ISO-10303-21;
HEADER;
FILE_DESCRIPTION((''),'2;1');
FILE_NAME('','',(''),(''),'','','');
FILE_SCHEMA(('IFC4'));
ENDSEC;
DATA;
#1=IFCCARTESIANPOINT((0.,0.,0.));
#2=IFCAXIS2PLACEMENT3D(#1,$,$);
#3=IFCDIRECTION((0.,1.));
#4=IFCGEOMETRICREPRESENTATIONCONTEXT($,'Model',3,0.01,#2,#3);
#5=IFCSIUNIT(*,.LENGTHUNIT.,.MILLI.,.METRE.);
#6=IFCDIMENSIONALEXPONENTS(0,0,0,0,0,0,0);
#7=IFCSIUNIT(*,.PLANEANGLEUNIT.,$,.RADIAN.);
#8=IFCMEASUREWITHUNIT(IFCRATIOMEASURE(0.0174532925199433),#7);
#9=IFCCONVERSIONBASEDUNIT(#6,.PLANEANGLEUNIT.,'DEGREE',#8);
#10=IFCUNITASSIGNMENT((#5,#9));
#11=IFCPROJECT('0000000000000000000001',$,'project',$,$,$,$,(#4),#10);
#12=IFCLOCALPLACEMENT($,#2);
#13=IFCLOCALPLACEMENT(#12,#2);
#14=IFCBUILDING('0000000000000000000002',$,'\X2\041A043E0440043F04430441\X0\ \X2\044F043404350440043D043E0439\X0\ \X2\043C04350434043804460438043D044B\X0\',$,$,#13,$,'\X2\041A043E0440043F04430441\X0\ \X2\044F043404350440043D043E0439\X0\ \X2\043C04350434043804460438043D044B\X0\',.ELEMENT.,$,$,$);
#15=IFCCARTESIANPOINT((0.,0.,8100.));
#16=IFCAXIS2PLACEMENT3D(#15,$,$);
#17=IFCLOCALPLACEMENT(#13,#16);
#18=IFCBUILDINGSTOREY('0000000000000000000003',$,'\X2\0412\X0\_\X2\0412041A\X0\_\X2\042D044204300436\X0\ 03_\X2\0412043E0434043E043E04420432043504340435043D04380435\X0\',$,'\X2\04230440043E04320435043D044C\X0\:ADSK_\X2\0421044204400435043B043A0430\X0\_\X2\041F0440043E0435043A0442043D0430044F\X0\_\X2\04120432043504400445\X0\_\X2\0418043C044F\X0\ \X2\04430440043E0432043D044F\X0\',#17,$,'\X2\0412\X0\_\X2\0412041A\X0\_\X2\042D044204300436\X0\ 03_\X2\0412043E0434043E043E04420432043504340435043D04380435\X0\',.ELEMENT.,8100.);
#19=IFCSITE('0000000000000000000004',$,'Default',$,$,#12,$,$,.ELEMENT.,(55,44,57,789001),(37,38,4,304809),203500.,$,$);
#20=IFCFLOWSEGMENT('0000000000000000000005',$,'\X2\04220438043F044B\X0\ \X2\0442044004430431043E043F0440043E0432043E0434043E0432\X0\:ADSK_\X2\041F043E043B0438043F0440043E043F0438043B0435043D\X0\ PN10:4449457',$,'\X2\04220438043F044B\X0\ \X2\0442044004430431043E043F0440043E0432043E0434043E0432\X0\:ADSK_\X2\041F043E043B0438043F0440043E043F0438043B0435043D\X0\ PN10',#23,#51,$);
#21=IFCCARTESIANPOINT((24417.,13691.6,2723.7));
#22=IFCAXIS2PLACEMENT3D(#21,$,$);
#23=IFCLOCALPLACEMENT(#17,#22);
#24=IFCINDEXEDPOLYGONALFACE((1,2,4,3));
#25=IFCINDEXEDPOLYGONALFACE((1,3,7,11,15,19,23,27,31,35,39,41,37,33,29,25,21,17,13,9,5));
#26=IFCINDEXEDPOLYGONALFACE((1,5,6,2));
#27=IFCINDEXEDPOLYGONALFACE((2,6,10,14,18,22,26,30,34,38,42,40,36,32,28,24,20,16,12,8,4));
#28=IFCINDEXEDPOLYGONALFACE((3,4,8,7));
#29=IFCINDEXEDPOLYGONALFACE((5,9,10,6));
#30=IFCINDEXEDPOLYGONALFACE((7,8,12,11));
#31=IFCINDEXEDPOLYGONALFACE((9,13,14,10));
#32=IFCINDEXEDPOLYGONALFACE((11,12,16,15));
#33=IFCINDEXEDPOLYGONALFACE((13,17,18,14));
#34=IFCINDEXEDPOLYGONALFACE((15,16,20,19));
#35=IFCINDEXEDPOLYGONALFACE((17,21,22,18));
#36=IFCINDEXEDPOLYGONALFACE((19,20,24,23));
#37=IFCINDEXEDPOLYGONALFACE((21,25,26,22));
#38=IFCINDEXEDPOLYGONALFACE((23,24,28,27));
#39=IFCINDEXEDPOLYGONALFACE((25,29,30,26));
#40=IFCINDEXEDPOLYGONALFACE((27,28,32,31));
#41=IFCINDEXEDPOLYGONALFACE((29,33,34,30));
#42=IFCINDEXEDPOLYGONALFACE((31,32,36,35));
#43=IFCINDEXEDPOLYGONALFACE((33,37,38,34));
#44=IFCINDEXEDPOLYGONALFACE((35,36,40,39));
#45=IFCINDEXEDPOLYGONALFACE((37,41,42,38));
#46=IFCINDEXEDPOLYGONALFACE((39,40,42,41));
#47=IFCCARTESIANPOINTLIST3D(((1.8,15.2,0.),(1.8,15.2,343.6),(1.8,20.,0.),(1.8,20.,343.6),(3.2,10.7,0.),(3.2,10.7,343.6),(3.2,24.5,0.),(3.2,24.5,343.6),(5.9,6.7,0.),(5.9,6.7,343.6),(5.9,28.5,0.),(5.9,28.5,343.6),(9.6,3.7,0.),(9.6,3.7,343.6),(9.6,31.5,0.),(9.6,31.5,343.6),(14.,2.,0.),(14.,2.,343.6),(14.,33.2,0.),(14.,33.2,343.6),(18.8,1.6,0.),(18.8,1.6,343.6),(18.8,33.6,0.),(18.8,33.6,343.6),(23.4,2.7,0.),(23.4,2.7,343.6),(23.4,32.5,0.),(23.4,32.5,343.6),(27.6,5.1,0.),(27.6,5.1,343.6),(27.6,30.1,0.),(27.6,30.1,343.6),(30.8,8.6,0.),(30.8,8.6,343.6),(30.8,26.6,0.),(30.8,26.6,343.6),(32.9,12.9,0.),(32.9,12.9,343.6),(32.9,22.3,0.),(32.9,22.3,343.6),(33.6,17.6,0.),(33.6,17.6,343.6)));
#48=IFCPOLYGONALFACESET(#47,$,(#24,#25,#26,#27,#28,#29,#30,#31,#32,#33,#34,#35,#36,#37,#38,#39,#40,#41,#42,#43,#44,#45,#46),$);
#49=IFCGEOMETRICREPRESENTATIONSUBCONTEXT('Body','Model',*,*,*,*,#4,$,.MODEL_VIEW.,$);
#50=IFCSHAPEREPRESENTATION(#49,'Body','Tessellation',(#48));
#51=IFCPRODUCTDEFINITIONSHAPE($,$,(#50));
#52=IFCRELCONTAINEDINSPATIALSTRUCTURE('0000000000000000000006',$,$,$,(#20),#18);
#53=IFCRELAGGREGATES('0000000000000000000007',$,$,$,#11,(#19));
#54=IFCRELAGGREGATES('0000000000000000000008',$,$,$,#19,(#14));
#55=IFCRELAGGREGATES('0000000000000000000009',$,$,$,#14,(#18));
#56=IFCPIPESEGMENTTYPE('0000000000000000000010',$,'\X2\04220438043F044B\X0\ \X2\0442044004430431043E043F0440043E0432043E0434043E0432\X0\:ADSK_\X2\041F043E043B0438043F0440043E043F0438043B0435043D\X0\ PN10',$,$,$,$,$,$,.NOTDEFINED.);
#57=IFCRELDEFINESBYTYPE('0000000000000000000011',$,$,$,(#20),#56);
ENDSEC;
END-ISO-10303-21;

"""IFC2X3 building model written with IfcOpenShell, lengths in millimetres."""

from ifc_helpers import new_model, entity, si_unit, converted_unit, direction, frame, origin, origin_2d_with_axis, place, context, subcontext, project, spatial, circle, extrude, type_object, element, save


model = new_model("IFC2X3")

# Units and contexts
model_context = context("Model", 3, precision=0.01, world=origin(), true_north=direction((0.0, 1.0)))
body_context = subcontext(model_context, "Body", "Model", "MODEL_VIEW")
ifc_project = project(units=[si_unit("LENGTHUNIT", "METRE", prefix="MILLI"), converted_unit("PLANEANGLEUNIT", "DEGREE", entity("IfcRatioMeasure", 0.0174532925199433), si_unit("PLANEANGLEUNIT", "RADIAN"), dimensions=[0, 0, 0, 0, 0, 0, 0])], contexts=[model_context])

# Site, building, storey
site_placement = place(None, origin())
site = spatial("IfcSite", under=ifc_project, at=site_placement, Name="Default", CompositionType="ELEMENT", RefLatitude=(55, 44, 57, 789001), RefLongitude=(37, 38, 4, 304809), RefElevation=203500.0)
building_placement = place(site_placement, origin())
building = spatial("IfcBuilding", under=site, at=building_placement, Name="Корпус ядерной медицины", LongName="Корпус ядерной медицины", CompositionType="ELEMENT")
storey_placement = place(building_placement, frame((0.0, 0.0, 8100.0)))
storey = spatial("IfcBuildingStorey", under=building, at=storey_placement, Name="В_ВК_Этаж 03_Водоотведение", ObjectType="Уровень:ADSK_Стрелка_Проектная_Вверх_Имя уровня", LongName="В_ВК_Этаж 03_Водоотведение", CompositionType="ELEMENT", Elevation=8100.0)

# Flow segment
pipe_segment_type_1 = type_object("IfcPipeSegmentType", Name="Типы трубопроводов:ADSK_Полипропилен PN10", PredefinedType="NOTDEFINED")
flow_segment_1_placement = place(storey_placement, frame((24417.0, 13691.6, 2723.7)))
element("IfcFlowSegment", 1, at=flow_segment_1_placement, inside=storey, type_object=pipe_segment_type_1, Name="Типы трубопроводов:ADSK_Полипропилен PN10:4449457", ObjectType="Типы трубопроводов:ADSK_Полипропилен PN10", context=body_context, shape_type="SweptSolid", body=[
    extrude(circle(Radius=16.0, at=origin_2d_with_axis()), frame((17.6, 17.6, 0.0)), (0.0, 0.0, 1.0), 343.6),
])

save(model, "model.ifc")
